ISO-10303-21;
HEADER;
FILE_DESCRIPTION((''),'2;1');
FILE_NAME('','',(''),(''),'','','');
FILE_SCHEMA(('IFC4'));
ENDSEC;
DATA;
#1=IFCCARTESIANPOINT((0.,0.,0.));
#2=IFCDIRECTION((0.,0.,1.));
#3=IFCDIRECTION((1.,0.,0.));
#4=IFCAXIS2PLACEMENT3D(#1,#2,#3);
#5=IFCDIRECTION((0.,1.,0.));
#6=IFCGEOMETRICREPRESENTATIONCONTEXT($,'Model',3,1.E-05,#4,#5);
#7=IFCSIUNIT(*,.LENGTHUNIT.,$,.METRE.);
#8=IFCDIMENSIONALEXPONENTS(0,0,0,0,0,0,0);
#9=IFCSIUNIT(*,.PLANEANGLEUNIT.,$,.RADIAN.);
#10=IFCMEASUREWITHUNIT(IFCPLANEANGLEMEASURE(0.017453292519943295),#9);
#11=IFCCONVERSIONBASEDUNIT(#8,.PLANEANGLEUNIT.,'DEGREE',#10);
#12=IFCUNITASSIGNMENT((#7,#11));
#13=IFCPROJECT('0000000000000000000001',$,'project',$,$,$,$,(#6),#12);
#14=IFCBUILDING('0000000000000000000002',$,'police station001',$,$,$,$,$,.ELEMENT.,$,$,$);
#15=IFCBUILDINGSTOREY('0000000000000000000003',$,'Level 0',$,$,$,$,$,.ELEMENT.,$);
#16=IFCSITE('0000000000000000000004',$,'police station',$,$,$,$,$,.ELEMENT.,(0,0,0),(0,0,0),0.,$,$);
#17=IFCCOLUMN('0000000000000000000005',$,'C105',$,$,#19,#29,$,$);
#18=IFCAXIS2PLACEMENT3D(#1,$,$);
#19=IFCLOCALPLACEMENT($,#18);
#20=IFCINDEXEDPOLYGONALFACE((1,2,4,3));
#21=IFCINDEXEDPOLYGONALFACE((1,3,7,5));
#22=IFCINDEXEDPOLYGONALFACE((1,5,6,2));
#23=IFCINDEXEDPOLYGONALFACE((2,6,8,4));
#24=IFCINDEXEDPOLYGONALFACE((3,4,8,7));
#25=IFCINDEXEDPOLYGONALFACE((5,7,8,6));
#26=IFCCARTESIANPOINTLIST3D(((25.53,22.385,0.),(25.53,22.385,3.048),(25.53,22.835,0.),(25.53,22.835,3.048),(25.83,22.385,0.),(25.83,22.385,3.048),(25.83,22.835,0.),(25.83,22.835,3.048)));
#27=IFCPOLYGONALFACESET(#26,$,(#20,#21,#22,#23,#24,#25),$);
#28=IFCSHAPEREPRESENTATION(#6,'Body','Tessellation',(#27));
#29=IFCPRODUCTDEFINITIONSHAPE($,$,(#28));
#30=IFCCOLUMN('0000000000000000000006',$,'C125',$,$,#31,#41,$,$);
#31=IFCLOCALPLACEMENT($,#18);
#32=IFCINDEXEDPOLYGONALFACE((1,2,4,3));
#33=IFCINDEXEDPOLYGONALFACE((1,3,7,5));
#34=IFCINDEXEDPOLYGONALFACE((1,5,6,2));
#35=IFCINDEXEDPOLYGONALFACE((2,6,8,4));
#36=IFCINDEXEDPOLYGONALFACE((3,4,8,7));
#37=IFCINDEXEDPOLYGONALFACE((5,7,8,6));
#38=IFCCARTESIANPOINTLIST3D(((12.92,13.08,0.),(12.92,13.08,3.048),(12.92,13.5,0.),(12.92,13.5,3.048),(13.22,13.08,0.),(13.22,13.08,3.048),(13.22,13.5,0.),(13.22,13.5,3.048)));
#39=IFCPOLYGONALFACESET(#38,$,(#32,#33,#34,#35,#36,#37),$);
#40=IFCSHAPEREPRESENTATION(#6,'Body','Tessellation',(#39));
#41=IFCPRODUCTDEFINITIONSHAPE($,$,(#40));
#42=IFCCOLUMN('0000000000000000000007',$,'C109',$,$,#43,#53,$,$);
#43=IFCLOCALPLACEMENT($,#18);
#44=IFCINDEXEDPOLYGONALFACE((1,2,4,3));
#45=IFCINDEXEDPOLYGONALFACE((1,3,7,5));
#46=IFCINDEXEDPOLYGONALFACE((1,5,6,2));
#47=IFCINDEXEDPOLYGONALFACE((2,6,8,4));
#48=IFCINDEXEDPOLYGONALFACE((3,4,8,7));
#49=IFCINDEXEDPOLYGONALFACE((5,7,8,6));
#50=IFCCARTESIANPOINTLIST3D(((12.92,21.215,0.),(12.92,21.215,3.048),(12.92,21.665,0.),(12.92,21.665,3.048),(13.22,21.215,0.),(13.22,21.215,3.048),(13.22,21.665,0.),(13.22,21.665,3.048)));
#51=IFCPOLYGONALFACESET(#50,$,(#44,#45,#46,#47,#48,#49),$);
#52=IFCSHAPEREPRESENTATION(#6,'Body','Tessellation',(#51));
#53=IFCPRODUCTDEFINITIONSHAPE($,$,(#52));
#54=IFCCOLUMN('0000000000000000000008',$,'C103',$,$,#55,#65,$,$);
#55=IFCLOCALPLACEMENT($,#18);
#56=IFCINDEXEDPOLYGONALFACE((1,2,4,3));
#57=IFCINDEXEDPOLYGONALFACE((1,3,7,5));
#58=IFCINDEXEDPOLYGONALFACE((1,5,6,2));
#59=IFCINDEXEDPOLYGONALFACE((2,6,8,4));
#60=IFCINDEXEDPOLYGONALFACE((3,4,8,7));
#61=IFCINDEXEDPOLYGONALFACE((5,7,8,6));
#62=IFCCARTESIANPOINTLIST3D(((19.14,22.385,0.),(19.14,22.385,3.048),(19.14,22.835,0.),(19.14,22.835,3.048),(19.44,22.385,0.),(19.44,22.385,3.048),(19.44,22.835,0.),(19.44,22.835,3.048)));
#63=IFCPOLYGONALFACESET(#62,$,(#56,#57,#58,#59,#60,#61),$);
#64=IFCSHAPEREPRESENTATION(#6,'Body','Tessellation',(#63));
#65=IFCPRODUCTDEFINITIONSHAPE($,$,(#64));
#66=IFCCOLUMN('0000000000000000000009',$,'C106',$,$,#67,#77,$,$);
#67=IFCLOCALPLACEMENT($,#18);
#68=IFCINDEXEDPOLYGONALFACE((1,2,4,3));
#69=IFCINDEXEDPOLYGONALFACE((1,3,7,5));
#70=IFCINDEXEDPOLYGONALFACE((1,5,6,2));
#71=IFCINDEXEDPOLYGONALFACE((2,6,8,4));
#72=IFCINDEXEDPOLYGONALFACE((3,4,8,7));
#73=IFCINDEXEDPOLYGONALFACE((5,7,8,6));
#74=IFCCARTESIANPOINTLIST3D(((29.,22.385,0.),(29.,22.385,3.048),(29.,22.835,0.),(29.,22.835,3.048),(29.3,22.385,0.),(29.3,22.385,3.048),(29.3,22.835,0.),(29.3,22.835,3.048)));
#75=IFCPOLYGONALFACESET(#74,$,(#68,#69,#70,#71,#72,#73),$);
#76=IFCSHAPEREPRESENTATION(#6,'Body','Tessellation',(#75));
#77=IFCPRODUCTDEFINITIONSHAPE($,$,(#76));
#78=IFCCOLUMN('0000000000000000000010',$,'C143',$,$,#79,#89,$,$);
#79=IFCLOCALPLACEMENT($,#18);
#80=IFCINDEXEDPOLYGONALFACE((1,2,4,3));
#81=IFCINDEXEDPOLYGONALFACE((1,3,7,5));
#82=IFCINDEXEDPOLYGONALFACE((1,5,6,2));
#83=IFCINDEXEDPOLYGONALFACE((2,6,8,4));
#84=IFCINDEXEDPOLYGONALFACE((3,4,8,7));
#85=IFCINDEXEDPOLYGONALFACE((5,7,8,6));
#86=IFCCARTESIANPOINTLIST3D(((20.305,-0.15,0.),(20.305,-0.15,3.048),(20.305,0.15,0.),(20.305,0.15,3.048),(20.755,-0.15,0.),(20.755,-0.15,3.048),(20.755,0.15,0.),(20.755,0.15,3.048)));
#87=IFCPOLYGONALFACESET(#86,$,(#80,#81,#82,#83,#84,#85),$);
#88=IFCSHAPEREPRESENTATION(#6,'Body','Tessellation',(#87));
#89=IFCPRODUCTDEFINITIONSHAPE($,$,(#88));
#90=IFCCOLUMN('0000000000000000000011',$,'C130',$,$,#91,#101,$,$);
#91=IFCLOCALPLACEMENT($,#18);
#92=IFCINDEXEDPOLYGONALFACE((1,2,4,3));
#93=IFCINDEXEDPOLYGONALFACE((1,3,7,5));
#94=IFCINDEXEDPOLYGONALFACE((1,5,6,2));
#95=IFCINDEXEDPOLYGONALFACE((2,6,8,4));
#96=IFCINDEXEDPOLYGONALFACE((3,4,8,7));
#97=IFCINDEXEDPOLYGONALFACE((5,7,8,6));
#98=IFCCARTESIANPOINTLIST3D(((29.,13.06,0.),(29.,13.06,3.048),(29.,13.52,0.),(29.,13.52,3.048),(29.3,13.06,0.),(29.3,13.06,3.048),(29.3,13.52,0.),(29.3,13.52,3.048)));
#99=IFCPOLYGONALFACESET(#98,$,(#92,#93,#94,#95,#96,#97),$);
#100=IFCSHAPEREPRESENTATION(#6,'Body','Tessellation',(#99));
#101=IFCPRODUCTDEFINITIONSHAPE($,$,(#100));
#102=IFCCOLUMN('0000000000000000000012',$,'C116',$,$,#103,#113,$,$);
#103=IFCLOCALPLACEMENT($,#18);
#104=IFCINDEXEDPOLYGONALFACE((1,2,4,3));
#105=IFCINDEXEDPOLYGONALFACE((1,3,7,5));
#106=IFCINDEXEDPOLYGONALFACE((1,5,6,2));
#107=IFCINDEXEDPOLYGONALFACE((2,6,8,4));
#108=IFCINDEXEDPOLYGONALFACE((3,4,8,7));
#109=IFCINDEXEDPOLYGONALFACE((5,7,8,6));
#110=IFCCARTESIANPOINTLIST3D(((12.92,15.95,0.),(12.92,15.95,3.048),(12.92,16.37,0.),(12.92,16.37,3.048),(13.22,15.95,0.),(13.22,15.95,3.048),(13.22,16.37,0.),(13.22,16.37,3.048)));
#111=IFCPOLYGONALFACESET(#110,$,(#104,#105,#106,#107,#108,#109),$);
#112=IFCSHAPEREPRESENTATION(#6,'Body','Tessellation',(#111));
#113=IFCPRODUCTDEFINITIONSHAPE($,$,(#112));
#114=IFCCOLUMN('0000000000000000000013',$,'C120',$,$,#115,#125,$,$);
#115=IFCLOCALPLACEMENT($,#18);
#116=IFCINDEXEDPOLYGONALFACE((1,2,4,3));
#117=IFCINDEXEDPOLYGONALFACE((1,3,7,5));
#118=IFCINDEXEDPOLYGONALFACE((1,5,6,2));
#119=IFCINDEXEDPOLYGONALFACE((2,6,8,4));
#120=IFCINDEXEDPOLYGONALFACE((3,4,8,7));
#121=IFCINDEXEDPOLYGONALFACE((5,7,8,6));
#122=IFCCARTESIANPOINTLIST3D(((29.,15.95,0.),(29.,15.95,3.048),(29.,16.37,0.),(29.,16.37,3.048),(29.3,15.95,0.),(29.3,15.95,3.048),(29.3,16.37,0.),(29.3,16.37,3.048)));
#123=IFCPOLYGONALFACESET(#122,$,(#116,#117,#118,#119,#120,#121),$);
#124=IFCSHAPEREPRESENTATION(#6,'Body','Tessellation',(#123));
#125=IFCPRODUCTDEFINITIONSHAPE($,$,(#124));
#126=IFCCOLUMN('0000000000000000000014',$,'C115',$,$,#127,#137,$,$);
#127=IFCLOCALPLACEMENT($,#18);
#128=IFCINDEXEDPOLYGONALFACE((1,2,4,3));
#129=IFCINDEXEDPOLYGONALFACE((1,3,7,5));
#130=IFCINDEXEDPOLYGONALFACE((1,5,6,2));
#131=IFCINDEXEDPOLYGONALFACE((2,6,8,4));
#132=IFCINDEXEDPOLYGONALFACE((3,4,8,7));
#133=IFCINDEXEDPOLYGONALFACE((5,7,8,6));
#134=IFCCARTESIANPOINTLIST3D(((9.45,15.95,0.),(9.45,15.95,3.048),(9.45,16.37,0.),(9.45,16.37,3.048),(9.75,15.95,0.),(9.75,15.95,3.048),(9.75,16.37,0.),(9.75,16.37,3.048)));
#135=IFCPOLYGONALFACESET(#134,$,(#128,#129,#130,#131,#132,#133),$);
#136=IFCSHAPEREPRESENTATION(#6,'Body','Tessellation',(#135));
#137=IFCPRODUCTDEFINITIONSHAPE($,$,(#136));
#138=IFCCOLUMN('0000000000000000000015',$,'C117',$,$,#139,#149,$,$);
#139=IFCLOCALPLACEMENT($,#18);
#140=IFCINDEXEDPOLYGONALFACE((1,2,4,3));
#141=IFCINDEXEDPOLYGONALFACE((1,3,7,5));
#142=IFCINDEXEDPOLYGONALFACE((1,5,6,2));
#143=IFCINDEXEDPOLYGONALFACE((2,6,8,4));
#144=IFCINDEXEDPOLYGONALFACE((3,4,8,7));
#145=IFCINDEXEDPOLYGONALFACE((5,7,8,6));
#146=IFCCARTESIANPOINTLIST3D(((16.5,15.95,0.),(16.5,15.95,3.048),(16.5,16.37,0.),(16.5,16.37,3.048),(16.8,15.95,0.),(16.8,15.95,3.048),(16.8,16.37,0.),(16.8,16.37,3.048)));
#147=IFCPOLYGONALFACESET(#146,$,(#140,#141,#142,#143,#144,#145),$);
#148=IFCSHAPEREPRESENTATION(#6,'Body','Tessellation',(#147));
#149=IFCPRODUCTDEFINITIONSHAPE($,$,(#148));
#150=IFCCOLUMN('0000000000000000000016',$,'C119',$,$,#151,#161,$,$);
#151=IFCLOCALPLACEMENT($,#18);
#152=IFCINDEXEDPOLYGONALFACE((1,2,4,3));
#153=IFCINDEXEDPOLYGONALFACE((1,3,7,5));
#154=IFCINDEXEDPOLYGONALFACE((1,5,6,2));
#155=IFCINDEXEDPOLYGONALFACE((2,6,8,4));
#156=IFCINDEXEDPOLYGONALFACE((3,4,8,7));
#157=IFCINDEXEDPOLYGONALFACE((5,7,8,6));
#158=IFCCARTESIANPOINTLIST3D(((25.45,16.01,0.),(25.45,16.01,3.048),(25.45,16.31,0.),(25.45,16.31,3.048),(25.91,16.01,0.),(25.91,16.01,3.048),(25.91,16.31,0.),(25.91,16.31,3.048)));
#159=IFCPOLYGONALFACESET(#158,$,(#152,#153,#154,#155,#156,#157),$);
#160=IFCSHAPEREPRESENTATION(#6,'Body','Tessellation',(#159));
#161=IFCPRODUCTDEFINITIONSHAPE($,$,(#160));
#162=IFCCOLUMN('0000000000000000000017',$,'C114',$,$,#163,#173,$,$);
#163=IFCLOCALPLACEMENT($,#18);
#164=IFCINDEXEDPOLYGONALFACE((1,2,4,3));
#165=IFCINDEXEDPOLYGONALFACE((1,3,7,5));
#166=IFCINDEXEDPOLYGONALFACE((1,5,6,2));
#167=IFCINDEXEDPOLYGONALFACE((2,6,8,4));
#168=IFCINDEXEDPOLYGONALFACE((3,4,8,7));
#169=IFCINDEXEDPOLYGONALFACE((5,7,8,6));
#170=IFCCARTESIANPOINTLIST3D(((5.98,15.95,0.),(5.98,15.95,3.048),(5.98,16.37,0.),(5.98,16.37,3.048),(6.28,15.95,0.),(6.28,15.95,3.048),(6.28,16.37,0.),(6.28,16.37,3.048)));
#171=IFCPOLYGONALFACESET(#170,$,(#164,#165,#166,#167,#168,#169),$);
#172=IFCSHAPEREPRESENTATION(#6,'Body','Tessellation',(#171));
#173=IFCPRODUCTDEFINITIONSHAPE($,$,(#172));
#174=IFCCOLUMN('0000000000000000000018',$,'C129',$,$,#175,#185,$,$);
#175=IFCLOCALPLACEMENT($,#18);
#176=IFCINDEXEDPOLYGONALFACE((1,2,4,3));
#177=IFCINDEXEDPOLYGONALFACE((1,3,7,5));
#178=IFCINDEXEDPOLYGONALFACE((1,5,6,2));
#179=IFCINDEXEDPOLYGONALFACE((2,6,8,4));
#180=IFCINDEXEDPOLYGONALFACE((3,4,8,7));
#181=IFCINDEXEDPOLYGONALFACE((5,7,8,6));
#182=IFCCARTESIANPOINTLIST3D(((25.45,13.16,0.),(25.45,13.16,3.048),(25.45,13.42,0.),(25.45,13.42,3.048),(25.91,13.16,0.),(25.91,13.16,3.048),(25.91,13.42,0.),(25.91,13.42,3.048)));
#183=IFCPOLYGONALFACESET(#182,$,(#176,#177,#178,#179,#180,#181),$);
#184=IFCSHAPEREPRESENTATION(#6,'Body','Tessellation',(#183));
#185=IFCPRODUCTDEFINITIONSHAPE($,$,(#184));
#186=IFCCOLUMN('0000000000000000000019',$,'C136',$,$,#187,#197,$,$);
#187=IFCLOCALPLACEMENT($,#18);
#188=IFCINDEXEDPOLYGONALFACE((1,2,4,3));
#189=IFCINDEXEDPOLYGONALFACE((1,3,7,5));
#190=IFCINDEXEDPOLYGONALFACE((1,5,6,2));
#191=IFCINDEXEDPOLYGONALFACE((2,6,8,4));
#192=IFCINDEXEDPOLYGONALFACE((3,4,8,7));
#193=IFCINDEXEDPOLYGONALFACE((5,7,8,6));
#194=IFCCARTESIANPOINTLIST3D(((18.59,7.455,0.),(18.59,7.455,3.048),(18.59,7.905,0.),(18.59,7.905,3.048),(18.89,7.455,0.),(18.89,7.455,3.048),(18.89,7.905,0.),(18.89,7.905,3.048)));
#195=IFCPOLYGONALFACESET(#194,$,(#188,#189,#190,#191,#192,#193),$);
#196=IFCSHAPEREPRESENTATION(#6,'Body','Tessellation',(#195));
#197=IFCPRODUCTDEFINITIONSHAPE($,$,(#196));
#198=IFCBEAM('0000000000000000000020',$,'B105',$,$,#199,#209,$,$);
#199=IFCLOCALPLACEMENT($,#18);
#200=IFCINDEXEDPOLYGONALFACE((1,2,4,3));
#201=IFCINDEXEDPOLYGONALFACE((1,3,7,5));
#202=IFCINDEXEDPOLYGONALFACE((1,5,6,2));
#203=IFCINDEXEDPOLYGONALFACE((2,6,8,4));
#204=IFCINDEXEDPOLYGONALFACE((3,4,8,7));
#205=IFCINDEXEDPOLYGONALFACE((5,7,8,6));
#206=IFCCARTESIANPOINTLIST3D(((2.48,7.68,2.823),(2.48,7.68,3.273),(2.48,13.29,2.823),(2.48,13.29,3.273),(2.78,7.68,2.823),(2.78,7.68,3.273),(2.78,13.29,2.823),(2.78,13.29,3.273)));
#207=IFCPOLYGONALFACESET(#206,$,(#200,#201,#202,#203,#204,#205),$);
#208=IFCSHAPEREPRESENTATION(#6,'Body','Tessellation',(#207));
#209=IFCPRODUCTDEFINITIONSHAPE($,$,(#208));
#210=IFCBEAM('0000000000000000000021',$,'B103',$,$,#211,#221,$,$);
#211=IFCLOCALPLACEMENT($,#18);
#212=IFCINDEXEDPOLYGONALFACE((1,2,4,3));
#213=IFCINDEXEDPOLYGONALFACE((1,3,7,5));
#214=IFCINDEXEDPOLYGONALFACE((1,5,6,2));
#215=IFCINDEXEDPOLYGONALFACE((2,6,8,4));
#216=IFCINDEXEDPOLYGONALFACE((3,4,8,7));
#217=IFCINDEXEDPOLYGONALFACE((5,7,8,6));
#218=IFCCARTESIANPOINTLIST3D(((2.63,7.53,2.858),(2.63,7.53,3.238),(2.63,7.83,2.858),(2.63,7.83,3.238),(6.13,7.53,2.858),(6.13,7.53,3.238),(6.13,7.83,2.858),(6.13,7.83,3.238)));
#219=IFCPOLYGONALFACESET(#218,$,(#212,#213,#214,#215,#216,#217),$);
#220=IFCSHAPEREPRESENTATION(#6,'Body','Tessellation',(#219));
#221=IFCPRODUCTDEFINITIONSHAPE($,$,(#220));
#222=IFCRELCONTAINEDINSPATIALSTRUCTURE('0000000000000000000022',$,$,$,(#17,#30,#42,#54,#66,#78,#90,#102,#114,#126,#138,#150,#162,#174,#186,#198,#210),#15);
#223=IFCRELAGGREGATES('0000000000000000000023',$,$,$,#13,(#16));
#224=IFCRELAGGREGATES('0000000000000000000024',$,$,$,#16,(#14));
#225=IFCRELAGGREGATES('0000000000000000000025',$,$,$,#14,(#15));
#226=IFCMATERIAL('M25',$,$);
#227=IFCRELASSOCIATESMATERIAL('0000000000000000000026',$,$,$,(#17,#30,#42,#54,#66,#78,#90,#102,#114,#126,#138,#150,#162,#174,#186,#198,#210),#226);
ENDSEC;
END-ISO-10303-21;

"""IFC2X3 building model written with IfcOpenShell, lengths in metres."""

from ifc_helpers import new_model, entity, si_unit, converted_unit, direction, frame, frame_2d, origin_with_axes, place, context, project, spatial, rectangle, extrude, material, element, save


model = new_model("IFC2X3")

# Units and contexts
model_context = context("Model", 3, precision=1e-05, world=origin_with_axes(), true_north=direction((0.0, 1.0, 0.0)))
ifc_project = project(units=[si_unit("LENGTHUNIT", "METRE"), converted_unit("PLANEANGLEUNIT", "DEGREE", entity("IfcPlaneAngleMeasure", 0.017453292519943295), si_unit("PLANEANGLEUNIT", "RADIAN"), dimensions=[0, 0, 0, 0, 0, 0, 0])], contexts=[model_context])

# Site, building, storey
site = spatial("IfcSite", under=ifc_project, Name="police station", CompositionType="ELEMENT", RefLatitude=(0, 0, 0), RefLongitude=(0, 0, 0), RefElevation=0.0)
building = spatial("IfcBuilding", under=site, Name="police station001", CompositionType="ELEMENT")
storey = spatial("IfcBuildingStorey", under=building, Name="Level 0", CompositionType="ELEMENT")

# Columns
ifc_material = material(Name="M25")
placement = place(None, origin_with_axes())
element("IfcColumn", 1, at=placement, inside=storey, material=ifc_material, Name="C105", context=model_context, shape_type="SweptSolid", body=[
    extrude(rectangle(XDim=0.3, YDim=0.45, at=frame_2d((0.0, 0.0), x_axis=(1.0, 0.0, 0.0))), frame((25.68, 22.61, 0.0), z_axis=(0.0, 0.0, 1.0), x_axis=(1.0, 0.0, 0.0)), (0.0, 0.0, 1.0), 3.048),
])
element("IfcColumn", 2, at=placement, inside=storey, material=ifc_material, Name="C125", context=model_context, shape_type="SweptSolid", body=[
    extrude(rectangle(XDim=0.3, YDim=0.42, at=frame_2d((0.0, 0.0), x_axis=(1.0, 0.0, 0.0))), frame((13.07, 13.29, 0.0), z_axis=(0.0, 0.0, 1.0), x_axis=(1.0, 0.0, 0.0)), (0.0, 0.0, 1.0), 3.048),
])
element("IfcColumn", 3, at=placement, inside=storey, material=ifc_material, Name="C109", context=model_context, shape_type="SweptSolid", body=[
    extrude(rectangle(XDim=0.3, YDim=0.45, at=frame_2d((0.0, 0.0), x_axis=(1.0, 0.0, 0.0))), frame((13.07, 21.44, 0.0), z_axis=(0.0, 0.0, 1.0), x_axis=(1.0, 0.0, 0.0)), (0.0, 0.0, 1.0), 3.048),
])
element("IfcColumn", 4, at=placement, inside=storey, material=ifc_material, Name="C103", context=model_context, shape_type="SweptSolid", body=[
    extrude(rectangle(XDim=0.3, YDim=0.45, at=frame_2d((0.0, 0.0), x_axis=(1.0, 0.0, 0.0))), frame((19.29, 22.61, 0.0), z_axis=(0.0, 0.0, 1.0), x_axis=(1.0, 0.0, 0.0)), (0.0, 0.0, 1.0), 3.048),
])
element("IfcColumn", 5, at=placement, inside=storey, material=ifc_material, Name="C106", context=model_context, shape_type="SweptSolid", body=[
    extrude(rectangle(XDim=0.3, YDim=0.45, at=frame_2d((0.0, 0.0), x_axis=(1.0, 0.0, 0.0))), frame((29.15, 22.61, 0.0), z_axis=(0.0, 0.0, 1.0), x_axis=(1.0, 0.0, 0.0)), (0.0, 0.0, 1.0), 3.048),
])
element("IfcColumn", 6, at=placement, inside=storey, material=ifc_material, Name="C143", context=model_context, shape_type="SweptSolid", body=[
    extrude(rectangle(XDim=0.45, YDim=0.3, at=frame_2d((0.0, 0.0), x_axis=(1.0, 0.0, 0.0))), frame((20.53, 0.0, 0.0), z_axis=(0.0, 0.0, 1.0), x_axis=(1.0, 0.0, 0.0)), (0.0, 0.0, 1.0), 3.048),
])
element("IfcColumn", 7, at=placement, inside=storey, material=ifc_material, Name="C130", context=model_context, shape_type="SweptSolid", body=[
    extrude(rectangle(XDim=0.3, YDim=0.46, at=frame_2d((0.0, 0.0), x_axis=(1.0, 0.0, 0.0))), frame((29.15, 13.29, 0.0), z_axis=(0.0, 0.0, 1.0), x_axis=(1.0, 0.0, 0.0)), (0.0, 0.0, 1.0), 3.048),
])
element("IfcColumn", 8, at=placement, inside=storey, material=ifc_material, Name="C116", context=model_context, shape_type="SweptSolid", body=[
    extrude(rectangle(XDim=0.3, YDim=0.42, at=frame_2d((0.0, 0.0), x_axis=(1.0, 0.0, 0.0))), frame((13.07, 16.16, 0.0), z_axis=(0.0, 0.0, 1.0), x_axis=(1.0, 0.0, 0.0)), (0.0, 0.0, 1.0), 3.048),
])
element("IfcColumn", 9, at=placement, inside=storey, material=ifc_material, Name="C120", context=model_context, shape_type="SweptSolid", body=[
    extrude(rectangle(XDim=0.3, YDim=0.42, at=frame_2d((0.0, 0.0), x_axis=(1.0, 0.0, 0.0))), frame((29.15, 16.16, 0.0), z_axis=(0.0, 0.0, 1.0), x_axis=(1.0, 0.0, 0.0)), (0.0, 0.0, 1.0), 3.048),
])
element("IfcColumn", 10, at=placement, inside=storey, material=ifc_material, Name="C115", context=model_context, shape_type="SweptSolid", body=[
    extrude(rectangle(XDim=0.3, YDim=0.42, at=frame_2d((0.0, 0.0), x_axis=(1.0, 0.0, 0.0))), frame((9.6, 16.16, 0.0), z_axis=(0.0, 0.0, 1.0), x_axis=(1.0, 0.0, 0.0)), (0.0, 0.0, 1.0), 3.048),
])
element("IfcColumn", 11, at=placement, inside=storey, material=ifc_material, Name="C117", context=model_context, shape_type="SweptSolid", body=[
    extrude(rectangle(XDim=0.3, YDim=0.42, at=frame_2d((0.0, 0.0), x_axis=(1.0, 0.0, 0.0))), frame((16.65, 16.16, 0.0), z_axis=(0.0, 0.0, 1.0), x_axis=(1.0, 0.0, 0.0)), (0.0, 0.0, 1.0), 3.048),
])
element("IfcColumn", 12, at=placement, inside=storey, material=ifc_material, Name="C119", context=model_context, shape_type="SweptSolid", body=[
    extrude(rectangle(XDim=0.46, YDim=0.3, at=frame_2d((0.0, 0.0), x_axis=(1.0, 0.0, 0.0))), frame((25.68, 16.16, 0.0), z_axis=(0.0, 0.0, 1.0), x_axis=(1.0, 0.0, 0.0)), (0.0, 0.0, 1.0), 3.048),
])
element("IfcColumn", 13, at=placement, inside=storey, material=ifc_material, Name="C114", context=model_context, shape_type="SweptSolid", body=[
    extrude(rectangle(XDim=0.3, YDim=0.42, at=frame_2d((0.0, 0.0), x_axis=(1.0, 0.0, 0.0))), frame((6.13, 16.16, 0.0), z_axis=(0.0, 0.0, 1.0), x_axis=(1.0, 0.0, 0.0)), (0.0, 0.0, 1.0), 3.048),
])
element("IfcColumn", 14, at=placement, inside=storey, material=ifc_material, Name="C129", context=model_context, shape_type="SweptSolid", body=[
    extrude(rectangle(XDim=0.46, YDim=0.26, at=frame_2d((0.0, 0.0), x_axis=(1.0, 0.0, 0.0))), frame((25.68, 13.29, 0.0), z_axis=(0.0, 0.0, 1.0), x_axis=(1.0, 0.0, 0.0)), (0.0, 0.0, 1.0), 3.048),
])
element("IfcColumn", 15, at=placement, inside=storey, material=ifc_material, Name="C136", context=model_context, shape_type="SweptSolid", body=[
    extrude(rectangle(XDim=0.3, YDim=0.45, at=frame_2d((0.0, 0.0), x_axis=(1.0, 0.0, 0.0))), frame((18.74, 7.68, 0.0), z_axis=(0.0, 0.0, 1.0), x_axis=(1.0, 0.0, 0.0)), (0.0, 0.0, 1.0), 3.048),
])

# Beams
element("IfcBeam", 16, at=placement, inside=storey, material=ifc_material, Name="B105", context=model_context, shape_type="SweptSolid", body=[
    extrude(rectangle(XDim=0.3, YDim=0.45, at=frame_2d((0.0, 0.0), x_axis=(0.0, 1.0, 0.0))), frame((2.63, 13.29, 3.048), z_axis=(0.0, -1.0, 0.0), x_axis=(0.0, 0.0, -1.0)), (0.0, 0.0, 1.0), 5.61),
])
element("IfcBeam", 17, at=placement, inside=storey, material=ifc_material, Name="B103", context=model_context, shape_type="SweptSolid", body=[
    extrude(rectangle(XDim=0.3, YDim=0.38, at=frame_2d((0.0, 0.0), x_axis=(0.0, 1.0, 0.0))), frame((2.63, 7.68, 3.048), z_axis=(1.0, 0.0, 0.0), x_axis=(0.0, 0.0, -1.0)), (0.0, 0.0, 1.0), 3.5),
])

save(model, "model.ifc")
